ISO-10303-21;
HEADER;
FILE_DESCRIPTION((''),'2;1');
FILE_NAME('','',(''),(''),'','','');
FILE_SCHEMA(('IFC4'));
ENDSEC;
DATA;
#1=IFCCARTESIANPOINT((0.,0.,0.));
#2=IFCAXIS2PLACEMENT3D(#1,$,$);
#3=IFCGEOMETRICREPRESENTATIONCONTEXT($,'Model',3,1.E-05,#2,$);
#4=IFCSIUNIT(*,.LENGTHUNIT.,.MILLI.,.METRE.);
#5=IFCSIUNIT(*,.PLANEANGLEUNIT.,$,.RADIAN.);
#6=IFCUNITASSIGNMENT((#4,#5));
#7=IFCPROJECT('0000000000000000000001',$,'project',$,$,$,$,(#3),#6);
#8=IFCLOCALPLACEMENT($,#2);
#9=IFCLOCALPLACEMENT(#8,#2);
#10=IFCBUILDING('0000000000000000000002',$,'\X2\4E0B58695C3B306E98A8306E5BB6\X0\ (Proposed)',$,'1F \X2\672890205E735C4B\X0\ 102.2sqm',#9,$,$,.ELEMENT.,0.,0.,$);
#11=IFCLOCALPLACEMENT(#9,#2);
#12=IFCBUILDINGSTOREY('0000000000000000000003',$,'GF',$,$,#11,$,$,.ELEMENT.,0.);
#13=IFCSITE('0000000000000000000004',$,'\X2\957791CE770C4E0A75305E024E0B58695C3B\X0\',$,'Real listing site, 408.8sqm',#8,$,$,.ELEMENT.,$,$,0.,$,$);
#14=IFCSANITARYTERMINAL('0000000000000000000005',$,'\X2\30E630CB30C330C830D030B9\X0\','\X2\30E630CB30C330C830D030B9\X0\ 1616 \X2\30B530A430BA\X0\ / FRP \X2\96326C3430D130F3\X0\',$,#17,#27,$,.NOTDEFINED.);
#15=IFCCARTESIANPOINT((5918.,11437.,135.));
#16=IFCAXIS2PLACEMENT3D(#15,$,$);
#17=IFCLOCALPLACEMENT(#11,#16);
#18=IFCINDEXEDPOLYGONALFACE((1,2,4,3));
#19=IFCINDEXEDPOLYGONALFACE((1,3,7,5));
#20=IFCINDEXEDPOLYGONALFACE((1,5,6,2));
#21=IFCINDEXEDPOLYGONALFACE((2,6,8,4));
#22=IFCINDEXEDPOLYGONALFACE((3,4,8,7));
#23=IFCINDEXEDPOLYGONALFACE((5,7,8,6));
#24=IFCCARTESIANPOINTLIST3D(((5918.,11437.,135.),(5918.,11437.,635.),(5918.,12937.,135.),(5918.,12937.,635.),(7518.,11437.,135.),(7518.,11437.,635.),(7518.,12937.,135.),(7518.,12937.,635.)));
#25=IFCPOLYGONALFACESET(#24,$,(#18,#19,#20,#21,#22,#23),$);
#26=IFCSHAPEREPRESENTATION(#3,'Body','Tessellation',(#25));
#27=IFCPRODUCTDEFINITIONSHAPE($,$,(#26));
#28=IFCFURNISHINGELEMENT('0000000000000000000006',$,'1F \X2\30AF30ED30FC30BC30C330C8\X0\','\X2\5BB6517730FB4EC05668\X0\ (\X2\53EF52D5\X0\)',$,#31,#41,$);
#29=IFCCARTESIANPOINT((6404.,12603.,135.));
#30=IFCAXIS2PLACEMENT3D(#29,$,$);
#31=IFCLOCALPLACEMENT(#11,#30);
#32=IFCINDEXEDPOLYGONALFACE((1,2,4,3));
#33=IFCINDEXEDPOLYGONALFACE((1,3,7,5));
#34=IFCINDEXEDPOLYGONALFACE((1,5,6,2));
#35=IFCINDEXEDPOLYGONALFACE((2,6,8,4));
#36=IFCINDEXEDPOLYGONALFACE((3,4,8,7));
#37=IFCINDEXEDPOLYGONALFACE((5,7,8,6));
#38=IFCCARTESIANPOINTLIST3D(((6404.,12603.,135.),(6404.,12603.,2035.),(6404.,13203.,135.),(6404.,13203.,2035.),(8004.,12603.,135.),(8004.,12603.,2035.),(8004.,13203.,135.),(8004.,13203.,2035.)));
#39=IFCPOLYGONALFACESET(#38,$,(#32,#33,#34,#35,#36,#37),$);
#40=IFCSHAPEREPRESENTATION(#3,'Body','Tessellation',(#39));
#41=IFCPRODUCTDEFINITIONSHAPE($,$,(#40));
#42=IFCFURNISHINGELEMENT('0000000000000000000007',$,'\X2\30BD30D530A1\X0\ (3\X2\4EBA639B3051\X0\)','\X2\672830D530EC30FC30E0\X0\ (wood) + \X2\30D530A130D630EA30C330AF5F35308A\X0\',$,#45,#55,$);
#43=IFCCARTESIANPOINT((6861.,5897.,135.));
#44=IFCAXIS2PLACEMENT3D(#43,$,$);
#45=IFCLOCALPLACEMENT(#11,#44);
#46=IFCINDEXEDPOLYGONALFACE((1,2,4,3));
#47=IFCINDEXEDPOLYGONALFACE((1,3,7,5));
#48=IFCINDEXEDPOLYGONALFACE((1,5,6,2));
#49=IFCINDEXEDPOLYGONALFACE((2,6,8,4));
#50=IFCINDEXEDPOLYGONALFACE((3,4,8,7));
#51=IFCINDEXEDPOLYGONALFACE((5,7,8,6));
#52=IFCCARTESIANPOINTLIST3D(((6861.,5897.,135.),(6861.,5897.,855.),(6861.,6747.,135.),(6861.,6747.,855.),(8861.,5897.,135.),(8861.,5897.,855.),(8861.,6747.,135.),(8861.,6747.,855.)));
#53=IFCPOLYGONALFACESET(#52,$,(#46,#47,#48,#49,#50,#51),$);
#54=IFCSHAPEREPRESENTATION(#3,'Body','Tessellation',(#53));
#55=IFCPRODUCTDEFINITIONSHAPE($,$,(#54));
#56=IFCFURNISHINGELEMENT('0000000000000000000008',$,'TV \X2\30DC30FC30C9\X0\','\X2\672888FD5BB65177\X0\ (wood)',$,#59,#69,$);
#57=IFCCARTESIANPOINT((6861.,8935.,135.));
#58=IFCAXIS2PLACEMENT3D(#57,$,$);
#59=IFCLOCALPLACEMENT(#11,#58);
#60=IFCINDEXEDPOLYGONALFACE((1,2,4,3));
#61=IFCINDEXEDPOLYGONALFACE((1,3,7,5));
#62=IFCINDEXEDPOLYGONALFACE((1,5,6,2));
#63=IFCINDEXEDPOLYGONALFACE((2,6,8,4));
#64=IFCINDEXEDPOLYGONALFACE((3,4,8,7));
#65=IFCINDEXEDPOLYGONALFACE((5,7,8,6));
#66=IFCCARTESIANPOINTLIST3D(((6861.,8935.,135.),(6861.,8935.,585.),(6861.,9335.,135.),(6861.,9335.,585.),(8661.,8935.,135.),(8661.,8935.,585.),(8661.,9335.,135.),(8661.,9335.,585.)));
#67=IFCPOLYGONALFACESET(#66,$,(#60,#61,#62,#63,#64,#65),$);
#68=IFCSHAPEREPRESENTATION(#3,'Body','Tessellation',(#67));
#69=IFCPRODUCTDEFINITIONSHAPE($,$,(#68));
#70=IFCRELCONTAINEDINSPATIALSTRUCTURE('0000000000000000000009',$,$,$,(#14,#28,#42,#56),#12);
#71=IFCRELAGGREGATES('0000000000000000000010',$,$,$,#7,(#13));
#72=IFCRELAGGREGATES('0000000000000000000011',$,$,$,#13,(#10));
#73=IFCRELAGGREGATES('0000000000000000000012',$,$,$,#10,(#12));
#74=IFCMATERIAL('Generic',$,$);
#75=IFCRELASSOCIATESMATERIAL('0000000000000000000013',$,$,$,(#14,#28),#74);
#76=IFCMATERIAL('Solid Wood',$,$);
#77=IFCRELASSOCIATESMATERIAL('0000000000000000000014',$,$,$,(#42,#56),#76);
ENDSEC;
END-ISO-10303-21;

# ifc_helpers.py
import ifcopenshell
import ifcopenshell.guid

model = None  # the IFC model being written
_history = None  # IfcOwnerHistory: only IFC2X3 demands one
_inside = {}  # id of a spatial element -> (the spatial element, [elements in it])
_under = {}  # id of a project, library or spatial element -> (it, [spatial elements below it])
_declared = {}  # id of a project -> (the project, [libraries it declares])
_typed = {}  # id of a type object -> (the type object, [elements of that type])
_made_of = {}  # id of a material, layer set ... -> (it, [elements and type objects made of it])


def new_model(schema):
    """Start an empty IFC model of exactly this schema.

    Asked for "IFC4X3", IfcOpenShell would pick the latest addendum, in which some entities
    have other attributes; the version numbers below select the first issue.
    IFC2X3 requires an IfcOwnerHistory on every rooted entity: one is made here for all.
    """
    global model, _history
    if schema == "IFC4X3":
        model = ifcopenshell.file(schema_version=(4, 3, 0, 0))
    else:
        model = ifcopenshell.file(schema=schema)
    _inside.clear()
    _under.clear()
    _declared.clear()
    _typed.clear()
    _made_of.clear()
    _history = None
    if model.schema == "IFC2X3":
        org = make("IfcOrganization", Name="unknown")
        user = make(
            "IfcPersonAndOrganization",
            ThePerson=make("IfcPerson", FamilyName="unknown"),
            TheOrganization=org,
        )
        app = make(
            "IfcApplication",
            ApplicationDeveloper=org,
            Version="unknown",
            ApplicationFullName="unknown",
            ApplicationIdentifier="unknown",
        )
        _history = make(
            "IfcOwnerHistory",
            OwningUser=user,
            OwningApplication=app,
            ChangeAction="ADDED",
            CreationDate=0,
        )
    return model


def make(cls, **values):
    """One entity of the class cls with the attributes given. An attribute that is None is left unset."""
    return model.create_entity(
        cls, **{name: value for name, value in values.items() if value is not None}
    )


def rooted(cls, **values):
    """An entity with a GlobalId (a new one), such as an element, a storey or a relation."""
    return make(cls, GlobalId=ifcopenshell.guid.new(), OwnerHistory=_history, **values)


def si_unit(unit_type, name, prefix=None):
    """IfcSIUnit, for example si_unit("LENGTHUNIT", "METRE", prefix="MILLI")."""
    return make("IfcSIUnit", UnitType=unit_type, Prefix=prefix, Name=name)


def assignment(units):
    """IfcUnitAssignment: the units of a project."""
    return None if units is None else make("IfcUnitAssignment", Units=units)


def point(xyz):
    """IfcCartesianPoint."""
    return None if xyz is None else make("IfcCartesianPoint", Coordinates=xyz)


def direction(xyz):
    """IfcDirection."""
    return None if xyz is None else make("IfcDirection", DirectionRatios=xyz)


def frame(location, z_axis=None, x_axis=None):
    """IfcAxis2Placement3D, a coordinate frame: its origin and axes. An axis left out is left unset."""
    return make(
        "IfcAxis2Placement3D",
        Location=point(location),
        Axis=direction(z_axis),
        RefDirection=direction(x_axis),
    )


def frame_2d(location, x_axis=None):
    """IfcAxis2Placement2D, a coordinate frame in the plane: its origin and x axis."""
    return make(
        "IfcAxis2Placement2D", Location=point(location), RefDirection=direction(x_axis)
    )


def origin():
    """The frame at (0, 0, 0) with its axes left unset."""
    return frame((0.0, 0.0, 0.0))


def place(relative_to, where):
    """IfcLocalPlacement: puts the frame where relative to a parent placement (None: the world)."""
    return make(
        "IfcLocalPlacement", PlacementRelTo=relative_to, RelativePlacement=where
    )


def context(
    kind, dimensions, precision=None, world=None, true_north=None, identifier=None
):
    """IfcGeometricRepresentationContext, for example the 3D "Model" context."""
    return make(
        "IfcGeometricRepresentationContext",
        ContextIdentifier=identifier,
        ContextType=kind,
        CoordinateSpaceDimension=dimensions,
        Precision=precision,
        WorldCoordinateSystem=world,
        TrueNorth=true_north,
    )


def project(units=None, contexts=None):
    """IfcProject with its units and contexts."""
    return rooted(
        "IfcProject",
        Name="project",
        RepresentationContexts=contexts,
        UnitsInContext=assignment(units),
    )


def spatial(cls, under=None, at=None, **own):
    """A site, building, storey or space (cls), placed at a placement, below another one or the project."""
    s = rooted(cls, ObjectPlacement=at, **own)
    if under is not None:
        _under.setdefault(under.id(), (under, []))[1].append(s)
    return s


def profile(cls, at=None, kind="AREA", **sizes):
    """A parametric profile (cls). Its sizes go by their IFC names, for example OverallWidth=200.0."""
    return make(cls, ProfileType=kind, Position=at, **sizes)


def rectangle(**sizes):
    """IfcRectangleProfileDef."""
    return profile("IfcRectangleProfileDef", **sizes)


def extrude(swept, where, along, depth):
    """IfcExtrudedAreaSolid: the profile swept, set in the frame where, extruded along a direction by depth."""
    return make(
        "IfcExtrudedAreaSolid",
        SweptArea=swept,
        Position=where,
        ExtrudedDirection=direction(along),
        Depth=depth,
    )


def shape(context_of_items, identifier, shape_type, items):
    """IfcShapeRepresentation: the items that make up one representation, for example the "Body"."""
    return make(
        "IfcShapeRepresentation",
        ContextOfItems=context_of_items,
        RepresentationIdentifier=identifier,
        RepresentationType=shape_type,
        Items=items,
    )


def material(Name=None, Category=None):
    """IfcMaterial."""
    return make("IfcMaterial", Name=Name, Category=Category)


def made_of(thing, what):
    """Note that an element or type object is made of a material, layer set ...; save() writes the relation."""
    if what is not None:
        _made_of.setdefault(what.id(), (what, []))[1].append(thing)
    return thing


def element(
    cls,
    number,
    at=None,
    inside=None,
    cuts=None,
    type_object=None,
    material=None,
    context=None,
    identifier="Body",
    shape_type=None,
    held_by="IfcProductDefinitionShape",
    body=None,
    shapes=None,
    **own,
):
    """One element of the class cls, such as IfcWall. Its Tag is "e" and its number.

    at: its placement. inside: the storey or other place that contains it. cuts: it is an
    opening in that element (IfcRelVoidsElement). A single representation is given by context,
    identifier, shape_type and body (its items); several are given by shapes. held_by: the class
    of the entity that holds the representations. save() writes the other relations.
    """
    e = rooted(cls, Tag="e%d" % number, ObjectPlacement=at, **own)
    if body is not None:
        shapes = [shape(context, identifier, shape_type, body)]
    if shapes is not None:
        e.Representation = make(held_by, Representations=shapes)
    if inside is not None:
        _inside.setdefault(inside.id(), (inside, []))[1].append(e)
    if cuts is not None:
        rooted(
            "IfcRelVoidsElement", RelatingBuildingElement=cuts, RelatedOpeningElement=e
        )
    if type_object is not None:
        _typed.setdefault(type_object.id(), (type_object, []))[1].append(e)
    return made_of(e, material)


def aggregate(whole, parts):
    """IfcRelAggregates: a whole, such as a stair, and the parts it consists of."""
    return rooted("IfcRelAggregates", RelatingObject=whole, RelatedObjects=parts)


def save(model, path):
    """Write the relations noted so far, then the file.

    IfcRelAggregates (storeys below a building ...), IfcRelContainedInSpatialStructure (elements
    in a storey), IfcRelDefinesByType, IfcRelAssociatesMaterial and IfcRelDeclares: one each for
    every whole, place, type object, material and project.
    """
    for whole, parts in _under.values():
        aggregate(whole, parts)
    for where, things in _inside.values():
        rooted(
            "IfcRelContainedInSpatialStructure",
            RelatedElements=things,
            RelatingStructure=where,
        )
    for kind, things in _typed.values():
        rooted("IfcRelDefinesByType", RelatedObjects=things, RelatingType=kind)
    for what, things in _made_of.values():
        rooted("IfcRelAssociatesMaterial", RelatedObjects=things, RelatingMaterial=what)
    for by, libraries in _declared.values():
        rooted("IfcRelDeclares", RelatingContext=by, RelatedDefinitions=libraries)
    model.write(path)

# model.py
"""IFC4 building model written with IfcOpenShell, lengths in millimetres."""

from ifc_helpers import new_model, si_unit, frame, frame_2d, origin, place, context, project, spatial, rectangle, extrude, material, element, save


model = new_model("IFC4")

# Units and contexts
model_context = context("Model", 3, precision=1e-05, world=origin())
ifc_project = project(units=[si_unit("LENGTHUNIT", "METRE", prefix="MILLI"), si_unit("PLANEANGLEUNIT", "RADIAN")], contexts=[model_context])

# Site, building, storey
site_placement = place(None, origin())
site = spatial("IfcSite", under=ifc_project, at=site_placement, Name="長野県上田市下塩尻", ObjectType="Real listing site, 408.8sqm", CompositionType="ELEMENT", RefElevation=0.0)
building_placement = place(site_placement, origin())
building = spatial("IfcBuilding", under=site, at=building_placement, Name="下塩尻の風の家 (Proposed)", ObjectType="1F 木造平屋 102.2sqm", CompositionType="ELEMENT", ElevationOfRefHeight=0.0, ElevationOfTerrain=0.0)
storey_placement = place(building_placement, origin())
storey = spatial("IfcBuildingStorey", under=building, at=storey_placement, Name="GF", CompositionType="ELEMENT", Elevation=0.0)

# Shared definitions
ifc_material_1 = material(Name="Solid Wood")

# Shared definitions
ifc_material_2 = material(Name="Generic")

# Sanitary terminal
sanitary_terminal_placement = place(storey_placement, frame((5918.0, 11437.0, 135.0)))
element("IfcSanitaryTerminal", 1, at=sanitary_terminal_placement, inside=storey, material=ifc_material_2, Name="ユニットバス", Description="ユニットバス 1616 サイズ / FRP 防水パン", PredefinedType="NOTDEFINED", context=model_context, shape_type="SweptSolid", body=[
    extrude(rectangle(XDim=1600.0, YDim=1500.0, at=frame_2d((800.0, 750.0))), frame((5918.0, 11437.0, 135.0)), (0.0, 0.0, 1.0), 500.0),
])

# Furnishing elements
furnishing_1_placement = place(storey_placement, frame((6404.0, 12603.0, 135.0)))
element("IfcFurnishingElement", 2, at=furnishing_1_placement, inside=storey, material=ifc_material_2, Name="1F クローゼット", Description="家具・什器 (可動)", context=model_context, shape_type="SweptSolid", body=[
    extrude(rectangle(XDim=1600.0, YDim=600.0, at=frame_2d((800.0, 300.0))), frame((6404.0, 12603.0, 135.0)), (0.0, 0.0, 1.0), 1900.0),
])
furnishing_2_placement = place(storey_placement, frame((6861.0, 5897.0, 135.0)))
element("IfcFurnishingElement", 3, at=furnishing_2_placement, inside=storey, material=ifc_material_1, Name="ソファ (3人掛け)", Description="木フレーム (wood) + ファブリック張り", context=model_context, shape_type="SweptSolid", body=[
    extrude(rectangle(XDim=2000.0, YDim=850.0, at=frame_2d((1000.0, 425.0))), frame((6861.0, 5897.0, 135.0)), (0.0, 0.0, 1.0), 720.0),
])
furnishing_3_placement = place(storey_placement, frame((6861.0, 8935.0, 135.0)))
element("IfcFurnishingElement", 4, at=furnishing_3_placement, inside=storey, material=ifc_material_1, Name="TV ボード", Description="木製家具 (wood)", context=model_context, shape_type="SweptSolid", body=[
    extrude(rectangle(XDim=1800.0, YDim=400.0, at=frame_2d((900.0, 200.0))), frame((6861.0, 8935.0, 135.0)), (0.0, 0.0, 1.0), 450.0),
])

save(model, "model.ifc")
